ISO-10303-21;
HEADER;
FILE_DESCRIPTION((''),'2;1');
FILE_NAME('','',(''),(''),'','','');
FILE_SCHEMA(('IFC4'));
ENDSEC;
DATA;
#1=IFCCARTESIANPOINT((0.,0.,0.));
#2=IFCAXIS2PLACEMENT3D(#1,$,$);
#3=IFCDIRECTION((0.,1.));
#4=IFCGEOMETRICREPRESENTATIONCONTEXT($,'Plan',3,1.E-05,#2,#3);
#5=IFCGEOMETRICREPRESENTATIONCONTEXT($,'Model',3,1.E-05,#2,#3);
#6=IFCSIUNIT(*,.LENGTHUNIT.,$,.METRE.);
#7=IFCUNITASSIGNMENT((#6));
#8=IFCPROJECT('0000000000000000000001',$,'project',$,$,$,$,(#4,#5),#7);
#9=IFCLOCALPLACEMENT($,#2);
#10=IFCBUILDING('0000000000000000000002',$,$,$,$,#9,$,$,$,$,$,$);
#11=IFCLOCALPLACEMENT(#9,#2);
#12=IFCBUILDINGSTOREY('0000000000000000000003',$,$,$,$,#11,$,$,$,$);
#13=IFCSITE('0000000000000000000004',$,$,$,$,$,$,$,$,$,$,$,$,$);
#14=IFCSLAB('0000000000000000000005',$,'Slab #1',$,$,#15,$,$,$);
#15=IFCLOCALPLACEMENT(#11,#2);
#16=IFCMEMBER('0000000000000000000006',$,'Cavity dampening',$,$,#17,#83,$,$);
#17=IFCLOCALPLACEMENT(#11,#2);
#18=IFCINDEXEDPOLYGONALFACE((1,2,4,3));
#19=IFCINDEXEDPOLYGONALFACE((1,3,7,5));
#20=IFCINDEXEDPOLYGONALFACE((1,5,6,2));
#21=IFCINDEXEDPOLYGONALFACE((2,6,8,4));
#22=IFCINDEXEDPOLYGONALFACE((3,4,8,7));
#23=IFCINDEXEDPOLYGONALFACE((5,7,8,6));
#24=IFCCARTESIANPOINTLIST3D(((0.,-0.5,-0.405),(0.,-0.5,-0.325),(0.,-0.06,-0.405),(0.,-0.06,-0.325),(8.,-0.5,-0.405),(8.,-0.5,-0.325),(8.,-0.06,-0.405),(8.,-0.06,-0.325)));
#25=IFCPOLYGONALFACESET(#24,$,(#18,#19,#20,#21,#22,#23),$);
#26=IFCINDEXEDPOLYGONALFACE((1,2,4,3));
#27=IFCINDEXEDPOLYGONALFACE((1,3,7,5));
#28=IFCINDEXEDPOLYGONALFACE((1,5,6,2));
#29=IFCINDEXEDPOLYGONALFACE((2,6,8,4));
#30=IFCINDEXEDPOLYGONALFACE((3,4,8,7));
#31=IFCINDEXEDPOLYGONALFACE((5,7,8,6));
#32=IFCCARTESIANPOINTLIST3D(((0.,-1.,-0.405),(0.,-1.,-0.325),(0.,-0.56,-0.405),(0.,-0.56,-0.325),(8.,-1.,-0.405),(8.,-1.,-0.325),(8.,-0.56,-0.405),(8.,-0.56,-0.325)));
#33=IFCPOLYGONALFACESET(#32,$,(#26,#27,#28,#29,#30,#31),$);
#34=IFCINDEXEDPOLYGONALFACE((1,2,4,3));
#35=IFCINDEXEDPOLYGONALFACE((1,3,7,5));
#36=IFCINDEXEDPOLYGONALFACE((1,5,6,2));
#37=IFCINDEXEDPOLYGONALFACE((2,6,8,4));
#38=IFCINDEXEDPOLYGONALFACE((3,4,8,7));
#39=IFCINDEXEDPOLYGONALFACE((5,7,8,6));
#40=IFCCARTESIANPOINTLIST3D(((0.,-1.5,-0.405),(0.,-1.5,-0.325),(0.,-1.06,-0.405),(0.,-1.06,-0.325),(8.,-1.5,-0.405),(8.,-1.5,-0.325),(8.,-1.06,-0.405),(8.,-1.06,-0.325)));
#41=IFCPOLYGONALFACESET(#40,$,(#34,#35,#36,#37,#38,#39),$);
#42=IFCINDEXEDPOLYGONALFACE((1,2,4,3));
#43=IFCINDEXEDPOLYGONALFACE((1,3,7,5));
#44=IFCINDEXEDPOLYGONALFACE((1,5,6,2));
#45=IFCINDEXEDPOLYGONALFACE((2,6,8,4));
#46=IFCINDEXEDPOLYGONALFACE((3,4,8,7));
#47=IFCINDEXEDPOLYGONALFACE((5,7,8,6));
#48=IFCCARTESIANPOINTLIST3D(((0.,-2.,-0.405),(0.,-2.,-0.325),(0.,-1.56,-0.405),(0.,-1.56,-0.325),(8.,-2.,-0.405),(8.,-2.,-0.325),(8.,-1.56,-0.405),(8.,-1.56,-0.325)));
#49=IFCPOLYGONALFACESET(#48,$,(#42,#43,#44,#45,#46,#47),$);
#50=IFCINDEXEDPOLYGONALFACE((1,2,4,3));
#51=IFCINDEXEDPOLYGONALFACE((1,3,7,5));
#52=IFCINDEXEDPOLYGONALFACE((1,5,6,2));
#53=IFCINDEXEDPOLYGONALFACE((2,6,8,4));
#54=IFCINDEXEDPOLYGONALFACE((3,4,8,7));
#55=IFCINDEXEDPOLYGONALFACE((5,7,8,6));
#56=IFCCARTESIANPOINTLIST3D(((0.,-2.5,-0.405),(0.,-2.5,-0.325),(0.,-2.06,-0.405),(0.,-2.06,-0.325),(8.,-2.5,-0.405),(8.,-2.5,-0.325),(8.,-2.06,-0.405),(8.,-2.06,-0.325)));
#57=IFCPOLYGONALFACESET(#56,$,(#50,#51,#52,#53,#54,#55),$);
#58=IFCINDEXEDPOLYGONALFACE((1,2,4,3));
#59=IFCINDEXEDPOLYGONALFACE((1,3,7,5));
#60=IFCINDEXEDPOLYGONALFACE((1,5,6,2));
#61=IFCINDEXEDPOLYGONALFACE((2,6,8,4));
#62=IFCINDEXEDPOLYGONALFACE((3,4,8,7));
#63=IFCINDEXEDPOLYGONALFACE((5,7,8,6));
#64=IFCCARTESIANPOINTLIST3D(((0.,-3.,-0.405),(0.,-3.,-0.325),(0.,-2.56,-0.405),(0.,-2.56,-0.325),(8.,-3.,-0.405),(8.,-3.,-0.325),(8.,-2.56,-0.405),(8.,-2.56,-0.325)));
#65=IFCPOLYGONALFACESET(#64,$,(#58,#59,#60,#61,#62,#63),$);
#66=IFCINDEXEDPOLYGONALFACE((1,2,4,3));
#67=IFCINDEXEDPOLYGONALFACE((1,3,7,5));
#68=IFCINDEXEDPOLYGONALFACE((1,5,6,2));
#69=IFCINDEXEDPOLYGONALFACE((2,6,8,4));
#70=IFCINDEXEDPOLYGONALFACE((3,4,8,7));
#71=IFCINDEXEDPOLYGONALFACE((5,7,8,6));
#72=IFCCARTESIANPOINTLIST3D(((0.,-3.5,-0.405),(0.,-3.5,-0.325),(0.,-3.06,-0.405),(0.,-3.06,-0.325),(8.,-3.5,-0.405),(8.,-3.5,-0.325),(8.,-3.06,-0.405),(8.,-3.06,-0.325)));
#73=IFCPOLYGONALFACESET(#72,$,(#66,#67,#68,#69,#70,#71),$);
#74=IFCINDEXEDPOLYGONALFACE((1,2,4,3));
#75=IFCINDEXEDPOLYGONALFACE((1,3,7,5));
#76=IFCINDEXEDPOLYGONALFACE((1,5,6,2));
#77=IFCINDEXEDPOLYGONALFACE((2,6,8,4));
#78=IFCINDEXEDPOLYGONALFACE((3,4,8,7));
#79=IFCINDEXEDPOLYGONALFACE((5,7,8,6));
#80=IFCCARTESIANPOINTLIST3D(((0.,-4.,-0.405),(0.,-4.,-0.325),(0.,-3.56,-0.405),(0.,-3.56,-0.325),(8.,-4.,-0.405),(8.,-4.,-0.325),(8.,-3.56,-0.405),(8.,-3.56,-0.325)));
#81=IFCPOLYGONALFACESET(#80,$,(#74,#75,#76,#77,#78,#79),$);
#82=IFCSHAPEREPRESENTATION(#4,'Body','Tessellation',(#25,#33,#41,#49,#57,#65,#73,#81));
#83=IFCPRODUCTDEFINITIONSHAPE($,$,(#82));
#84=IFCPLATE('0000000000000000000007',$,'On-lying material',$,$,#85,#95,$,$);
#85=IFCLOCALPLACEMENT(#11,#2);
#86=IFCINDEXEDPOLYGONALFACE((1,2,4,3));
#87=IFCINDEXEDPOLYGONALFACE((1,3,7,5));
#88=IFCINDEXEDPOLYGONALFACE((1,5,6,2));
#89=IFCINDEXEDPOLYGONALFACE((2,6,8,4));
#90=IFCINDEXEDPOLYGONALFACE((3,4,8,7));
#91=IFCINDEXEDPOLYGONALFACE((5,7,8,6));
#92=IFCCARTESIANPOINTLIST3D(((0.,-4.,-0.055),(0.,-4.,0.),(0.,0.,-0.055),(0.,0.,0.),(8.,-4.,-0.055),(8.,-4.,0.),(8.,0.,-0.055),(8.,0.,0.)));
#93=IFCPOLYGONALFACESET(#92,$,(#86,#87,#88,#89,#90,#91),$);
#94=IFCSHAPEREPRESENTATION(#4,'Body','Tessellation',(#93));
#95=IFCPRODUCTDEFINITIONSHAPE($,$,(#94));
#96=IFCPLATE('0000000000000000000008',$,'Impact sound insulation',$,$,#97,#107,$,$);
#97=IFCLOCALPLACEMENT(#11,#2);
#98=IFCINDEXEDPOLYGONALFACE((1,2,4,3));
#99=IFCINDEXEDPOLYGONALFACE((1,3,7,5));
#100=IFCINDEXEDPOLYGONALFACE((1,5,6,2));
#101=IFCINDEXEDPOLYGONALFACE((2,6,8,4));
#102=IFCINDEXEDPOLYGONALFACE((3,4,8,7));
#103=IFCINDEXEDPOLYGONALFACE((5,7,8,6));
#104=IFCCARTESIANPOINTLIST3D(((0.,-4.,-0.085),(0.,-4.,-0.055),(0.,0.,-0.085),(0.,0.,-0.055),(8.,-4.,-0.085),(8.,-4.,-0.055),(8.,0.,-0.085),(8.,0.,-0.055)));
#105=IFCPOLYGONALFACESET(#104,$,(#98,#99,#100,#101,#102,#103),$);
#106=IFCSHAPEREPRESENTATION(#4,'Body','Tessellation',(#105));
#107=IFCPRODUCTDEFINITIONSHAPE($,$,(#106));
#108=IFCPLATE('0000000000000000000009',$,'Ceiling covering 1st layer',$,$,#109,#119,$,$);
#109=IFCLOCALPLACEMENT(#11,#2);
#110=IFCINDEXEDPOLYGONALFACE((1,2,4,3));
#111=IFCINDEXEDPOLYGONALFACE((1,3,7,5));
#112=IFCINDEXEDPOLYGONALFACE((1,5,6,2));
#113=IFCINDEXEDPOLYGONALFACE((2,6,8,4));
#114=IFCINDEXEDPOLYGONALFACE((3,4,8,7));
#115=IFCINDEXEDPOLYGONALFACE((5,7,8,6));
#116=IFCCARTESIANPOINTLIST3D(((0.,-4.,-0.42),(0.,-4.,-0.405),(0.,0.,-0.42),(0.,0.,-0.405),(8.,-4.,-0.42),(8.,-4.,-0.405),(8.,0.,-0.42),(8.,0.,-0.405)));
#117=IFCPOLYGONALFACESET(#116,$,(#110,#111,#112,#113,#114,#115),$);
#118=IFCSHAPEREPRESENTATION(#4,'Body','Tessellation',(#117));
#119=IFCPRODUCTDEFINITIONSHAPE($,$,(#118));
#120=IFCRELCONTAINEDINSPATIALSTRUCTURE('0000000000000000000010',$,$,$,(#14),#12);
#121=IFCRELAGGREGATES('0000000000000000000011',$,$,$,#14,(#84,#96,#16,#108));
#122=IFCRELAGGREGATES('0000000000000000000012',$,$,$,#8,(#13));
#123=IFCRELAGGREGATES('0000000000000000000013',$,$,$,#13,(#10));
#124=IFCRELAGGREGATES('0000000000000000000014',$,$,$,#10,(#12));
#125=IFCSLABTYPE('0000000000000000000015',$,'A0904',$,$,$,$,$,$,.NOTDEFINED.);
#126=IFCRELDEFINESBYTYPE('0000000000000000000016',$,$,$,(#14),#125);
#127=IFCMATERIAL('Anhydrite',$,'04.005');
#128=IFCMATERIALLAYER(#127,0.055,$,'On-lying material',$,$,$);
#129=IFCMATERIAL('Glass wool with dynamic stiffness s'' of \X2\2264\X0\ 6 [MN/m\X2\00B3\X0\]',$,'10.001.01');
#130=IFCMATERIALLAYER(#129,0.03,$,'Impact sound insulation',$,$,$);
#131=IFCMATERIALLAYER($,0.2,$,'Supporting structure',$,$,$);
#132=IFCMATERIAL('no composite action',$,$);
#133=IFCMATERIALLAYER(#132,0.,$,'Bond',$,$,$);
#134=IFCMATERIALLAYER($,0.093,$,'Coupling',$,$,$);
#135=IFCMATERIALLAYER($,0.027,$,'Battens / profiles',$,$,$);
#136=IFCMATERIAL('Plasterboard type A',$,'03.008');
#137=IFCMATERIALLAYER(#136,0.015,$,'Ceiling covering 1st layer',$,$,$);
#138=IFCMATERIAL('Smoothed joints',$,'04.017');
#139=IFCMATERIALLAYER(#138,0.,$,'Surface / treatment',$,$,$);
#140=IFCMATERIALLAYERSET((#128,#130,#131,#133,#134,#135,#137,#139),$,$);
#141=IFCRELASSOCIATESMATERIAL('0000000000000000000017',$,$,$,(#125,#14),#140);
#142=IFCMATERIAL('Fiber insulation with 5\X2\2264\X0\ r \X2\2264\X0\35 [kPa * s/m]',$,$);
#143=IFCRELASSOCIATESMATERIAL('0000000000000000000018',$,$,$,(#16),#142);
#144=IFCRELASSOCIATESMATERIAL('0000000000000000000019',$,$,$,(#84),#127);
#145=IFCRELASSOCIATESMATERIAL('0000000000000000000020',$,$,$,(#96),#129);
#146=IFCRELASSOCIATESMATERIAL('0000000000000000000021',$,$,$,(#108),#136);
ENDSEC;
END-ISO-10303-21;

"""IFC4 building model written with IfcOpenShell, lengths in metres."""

from ifc_helpers import new_model, si_unit, direction, frame, frame_2d, origin, origin_with_axes, place, context, project, spatial, rectangle, extrude, material, layer, layer_set, type_object, element, aggregate, save


model = new_model("IFC4")

# Units and contexts
plan_context = context("Plan", 3, precision=1e-05, world=origin(), true_north=direction((0.0, 1.0)))
model_context = context("Model", 3, precision=1e-05, world=origin(), true_north=direction((0.0, 1.0)))
ifc_project = project(units=[si_unit("LENGTHUNIT", "METRE")], contexts=[plan_context, model_context])

# Site, building, storey
site = spatial("IfcSite", under=ifc_project)
building_placement = place(None, origin())
building = spatial("IfcBuilding", under=site, at=building_placement)
storey_placement = place(building_placement, origin())
storey = spatial("IfcBuildingStorey", under=building, at=storey_placement)

# Slab, member, plates
ifc_material_1 = material(Name="Anhydrite", Category="04.005")
ifc_layer_1 = layer(ifc_material_1, 0.055, Name="On-lying material")
ifc_material_2 = material(Name="Glass wool with dynamic stiffness s' of ≤ 6 [MN/m³]", Category="10.001.01")
ifc_layer_2 = layer(ifc_material_2, 0.03, Name="Impact sound insulation")
ifc_layer_3 = layer(None, 0.2, Name="Supporting structure")
ifc_material_3 = material(Name="no composite action")
ifc_layer_4 = layer(ifc_material_3, 0.0, Name="Bond")
ifc_layer_5 = layer(None, 0.093, Name="Coupling")
ifc_layer_6 = layer(None, 0.027, Name="Battens / profiles")
ifc_material_4 = material(Name="Plasterboard type A", Category="03.008")
ifc_layer_7 = layer(ifc_material_4, 0.015, Name="Ceiling covering 1st layer")
ifc_material_5 = material(Name="Smoothed joints", Category="04.017")
ifc_layer_8 = layer(ifc_material_5, 0.0, Name="Surface / treatment")
ifc_layer_set = layer_set([ifc_layer_1, ifc_layer_2, ifc_layer_3, ifc_layer_4, ifc_layer_5, ifc_layer_6, ifc_layer_7, ifc_layer_8])
slab_type = type_object("IfcSlabType", Name="A0904", PredefinedType="NOTDEFINED", material=ifc_layer_set)
slab_placement = place(None, frame((0.0, 0.0, 0.0), z_axis=(0.0, 0.0, -1.0), x_axis=(1.0, 0.0, 0.0)))
slab = element("IfcSlab", 1, at=slab_placement, inside=storey, type_object=slab_type, material=ifc_layer_set, Name="Slab #1")
ifc_material_6 = material(Name="Fiber insulation with 5≤ r ≤35 [kPa * s/m]")
member_1_placement = place(slab_placement, origin())
member_1 = element("IfcMember", 2, at=member_1_placement, material=ifc_material_6, Name="Cavity dampening", context=plan_context, shape_type="SweptSolid", body=[
    extrude(rectangle(XDim=0.44, YDim=0.08, at=frame_2d((0.22, 0.04), x_axis=(1.0, 0.0))), frame((0.0, 0.06, 0.325), z_axis=(1.0, 0.0, 0.0), x_axis=(0.0, 1.0, 0.0)), (0.0, 0.0, 1.0), 8.0),
    extrude(rectangle(XDim=0.44, YDim=0.08, at=frame_2d((0.22, 0.04), x_axis=(1.0, 0.0))), frame((0.0, 0.56, 0.325), z_axis=(1.0, 0.0, 0.0), x_axis=(0.0, 1.0, 0.0)), (0.0, 0.0, 1.0), 8.0),
    extrude(rectangle(XDim=0.44, YDim=0.08, at=frame_2d((0.22, 0.04), x_axis=(1.0, 0.0))), frame((0.0, 1.06, 0.325), z_axis=(1.0, 0.0, 0.0), x_axis=(0.0, 1.0, 0.0)), (0.0, 0.0, 1.0), 8.0),
    extrude(rectangle(XDim=0.44, YDim=0.08, at=frame_2d((0.22, 0.04), x_axis=(1.0, 0.0))), frame((0.0, 1.56, 0.325), z_axis=(1.0, 0.0, 0.0), x_axis=(0.0, 1.0, 0.0)), (0.0, 0.0, 1.0), 8.0),
    extrude(rectangle(XDim=0.44, YDim=0.08, at=frame_2d((0.22, 0.04), x_axis=(1.0, 0.0))), frame((0.0, 2.06, 0.325), z_axis=(1.0, 0.0, 0.0), x_axis=(0.0, 1.0, 0.0)), (0.0, 0.0, 1.0), 8.0),
    extrude(rectangle(XDim=0.44, YDim=0.08, at=frame_2d((0.22, 0.04), x_axis=(1.0, 0.0))), frame((0.0, 2.56, 0.325), z_axis=(1.0, 0.0, 0.0), x_axis=(0.0, 1.0, 0.0)), (0.0, 0.0, 1.0), 8.0),
    extrude(rectangle(XDim=0.44, YDim=0.08, at=frame_2d((0.22, 0.04), x_axis=(1.0, 0.0))), frame((0.0, 3.06, 0.325), z_axis=(1.0, 0.0, 0.0), x_axis=(0.0, 1.0, 0.0)), (0.0, 0.0, 1.0), 8.0),
    extrude(rectangle(XDim=0.44, YDim=0.08, at=frame_2d((0.22, 0.04), x_axis=(1.0, 0.0))), frame((0.0, 3.56, 0.325), z_axis=(1.0, 0.0, 0.0), x_axis=(0.0, 1.0, 0.0)), (0.0, 0.0, 1.0), 8.0),
])
plate_1_placement = place(slab_placement, origin())
plate_1 = element("IfcPlate", 3, at=plate_1_placement, material=ifc_material_1, Name="On-lying material", context=plan_context, shape_type="SweptSolid", body=[
    extrude(rectangle(XDim=8.0, YDim=4.0, at=frame_2d((4.0, 2.0), x_axis=(1.0, 0.0))), origin_with_axes(), (0.0, 0.0, 1.0), 0.055),
])
plate_2_placement = place(slab_placement, origin())
plate_2 = element("IfcPlate", 4, at=plate_2_placement, material=ifc_material_2, Name="Impact sound insulation", context=plan_context, shape_type="SweptSolid", body=[
    extrude(rectangle(XDim=8.0, YDim=4.0, at=frame_2d((4.0, 2.0), x_axis=(1.0, 0.0))), frame((0.0, 0.0, 0.055), z_axis=(0.0, 0.0, 1.0), x_axis=(1.0, 0.0, 0.0)), (0.0, 0.0, 1.0), 0.03),
])
plate_3_placement = place(slab_placement, origin())
plate_3 = element("IfcPlate", 5, at=plate_3_placement, material=ifc_material_4, Name="Ceiling covering 1st layer", context=plan_context, shape_type="SweptSolid", body=[
    extrude(rectangle(XDim=8.0, YDim=4.0, at=frame_2d((4.0, 2.0), x_axis=(1.0, 0.0))), frame((0.0, 0.0, 0.405), z_axis=(0.0, 0.0, 1.0), x_axis=(1.0, 0.0, 0.0)), (0.0, 0.0, 1.0), 0.015),
])
aggregate(slab, [plate_1, plate_2, member_1, plate_3])

save(model, "model.ifc")
